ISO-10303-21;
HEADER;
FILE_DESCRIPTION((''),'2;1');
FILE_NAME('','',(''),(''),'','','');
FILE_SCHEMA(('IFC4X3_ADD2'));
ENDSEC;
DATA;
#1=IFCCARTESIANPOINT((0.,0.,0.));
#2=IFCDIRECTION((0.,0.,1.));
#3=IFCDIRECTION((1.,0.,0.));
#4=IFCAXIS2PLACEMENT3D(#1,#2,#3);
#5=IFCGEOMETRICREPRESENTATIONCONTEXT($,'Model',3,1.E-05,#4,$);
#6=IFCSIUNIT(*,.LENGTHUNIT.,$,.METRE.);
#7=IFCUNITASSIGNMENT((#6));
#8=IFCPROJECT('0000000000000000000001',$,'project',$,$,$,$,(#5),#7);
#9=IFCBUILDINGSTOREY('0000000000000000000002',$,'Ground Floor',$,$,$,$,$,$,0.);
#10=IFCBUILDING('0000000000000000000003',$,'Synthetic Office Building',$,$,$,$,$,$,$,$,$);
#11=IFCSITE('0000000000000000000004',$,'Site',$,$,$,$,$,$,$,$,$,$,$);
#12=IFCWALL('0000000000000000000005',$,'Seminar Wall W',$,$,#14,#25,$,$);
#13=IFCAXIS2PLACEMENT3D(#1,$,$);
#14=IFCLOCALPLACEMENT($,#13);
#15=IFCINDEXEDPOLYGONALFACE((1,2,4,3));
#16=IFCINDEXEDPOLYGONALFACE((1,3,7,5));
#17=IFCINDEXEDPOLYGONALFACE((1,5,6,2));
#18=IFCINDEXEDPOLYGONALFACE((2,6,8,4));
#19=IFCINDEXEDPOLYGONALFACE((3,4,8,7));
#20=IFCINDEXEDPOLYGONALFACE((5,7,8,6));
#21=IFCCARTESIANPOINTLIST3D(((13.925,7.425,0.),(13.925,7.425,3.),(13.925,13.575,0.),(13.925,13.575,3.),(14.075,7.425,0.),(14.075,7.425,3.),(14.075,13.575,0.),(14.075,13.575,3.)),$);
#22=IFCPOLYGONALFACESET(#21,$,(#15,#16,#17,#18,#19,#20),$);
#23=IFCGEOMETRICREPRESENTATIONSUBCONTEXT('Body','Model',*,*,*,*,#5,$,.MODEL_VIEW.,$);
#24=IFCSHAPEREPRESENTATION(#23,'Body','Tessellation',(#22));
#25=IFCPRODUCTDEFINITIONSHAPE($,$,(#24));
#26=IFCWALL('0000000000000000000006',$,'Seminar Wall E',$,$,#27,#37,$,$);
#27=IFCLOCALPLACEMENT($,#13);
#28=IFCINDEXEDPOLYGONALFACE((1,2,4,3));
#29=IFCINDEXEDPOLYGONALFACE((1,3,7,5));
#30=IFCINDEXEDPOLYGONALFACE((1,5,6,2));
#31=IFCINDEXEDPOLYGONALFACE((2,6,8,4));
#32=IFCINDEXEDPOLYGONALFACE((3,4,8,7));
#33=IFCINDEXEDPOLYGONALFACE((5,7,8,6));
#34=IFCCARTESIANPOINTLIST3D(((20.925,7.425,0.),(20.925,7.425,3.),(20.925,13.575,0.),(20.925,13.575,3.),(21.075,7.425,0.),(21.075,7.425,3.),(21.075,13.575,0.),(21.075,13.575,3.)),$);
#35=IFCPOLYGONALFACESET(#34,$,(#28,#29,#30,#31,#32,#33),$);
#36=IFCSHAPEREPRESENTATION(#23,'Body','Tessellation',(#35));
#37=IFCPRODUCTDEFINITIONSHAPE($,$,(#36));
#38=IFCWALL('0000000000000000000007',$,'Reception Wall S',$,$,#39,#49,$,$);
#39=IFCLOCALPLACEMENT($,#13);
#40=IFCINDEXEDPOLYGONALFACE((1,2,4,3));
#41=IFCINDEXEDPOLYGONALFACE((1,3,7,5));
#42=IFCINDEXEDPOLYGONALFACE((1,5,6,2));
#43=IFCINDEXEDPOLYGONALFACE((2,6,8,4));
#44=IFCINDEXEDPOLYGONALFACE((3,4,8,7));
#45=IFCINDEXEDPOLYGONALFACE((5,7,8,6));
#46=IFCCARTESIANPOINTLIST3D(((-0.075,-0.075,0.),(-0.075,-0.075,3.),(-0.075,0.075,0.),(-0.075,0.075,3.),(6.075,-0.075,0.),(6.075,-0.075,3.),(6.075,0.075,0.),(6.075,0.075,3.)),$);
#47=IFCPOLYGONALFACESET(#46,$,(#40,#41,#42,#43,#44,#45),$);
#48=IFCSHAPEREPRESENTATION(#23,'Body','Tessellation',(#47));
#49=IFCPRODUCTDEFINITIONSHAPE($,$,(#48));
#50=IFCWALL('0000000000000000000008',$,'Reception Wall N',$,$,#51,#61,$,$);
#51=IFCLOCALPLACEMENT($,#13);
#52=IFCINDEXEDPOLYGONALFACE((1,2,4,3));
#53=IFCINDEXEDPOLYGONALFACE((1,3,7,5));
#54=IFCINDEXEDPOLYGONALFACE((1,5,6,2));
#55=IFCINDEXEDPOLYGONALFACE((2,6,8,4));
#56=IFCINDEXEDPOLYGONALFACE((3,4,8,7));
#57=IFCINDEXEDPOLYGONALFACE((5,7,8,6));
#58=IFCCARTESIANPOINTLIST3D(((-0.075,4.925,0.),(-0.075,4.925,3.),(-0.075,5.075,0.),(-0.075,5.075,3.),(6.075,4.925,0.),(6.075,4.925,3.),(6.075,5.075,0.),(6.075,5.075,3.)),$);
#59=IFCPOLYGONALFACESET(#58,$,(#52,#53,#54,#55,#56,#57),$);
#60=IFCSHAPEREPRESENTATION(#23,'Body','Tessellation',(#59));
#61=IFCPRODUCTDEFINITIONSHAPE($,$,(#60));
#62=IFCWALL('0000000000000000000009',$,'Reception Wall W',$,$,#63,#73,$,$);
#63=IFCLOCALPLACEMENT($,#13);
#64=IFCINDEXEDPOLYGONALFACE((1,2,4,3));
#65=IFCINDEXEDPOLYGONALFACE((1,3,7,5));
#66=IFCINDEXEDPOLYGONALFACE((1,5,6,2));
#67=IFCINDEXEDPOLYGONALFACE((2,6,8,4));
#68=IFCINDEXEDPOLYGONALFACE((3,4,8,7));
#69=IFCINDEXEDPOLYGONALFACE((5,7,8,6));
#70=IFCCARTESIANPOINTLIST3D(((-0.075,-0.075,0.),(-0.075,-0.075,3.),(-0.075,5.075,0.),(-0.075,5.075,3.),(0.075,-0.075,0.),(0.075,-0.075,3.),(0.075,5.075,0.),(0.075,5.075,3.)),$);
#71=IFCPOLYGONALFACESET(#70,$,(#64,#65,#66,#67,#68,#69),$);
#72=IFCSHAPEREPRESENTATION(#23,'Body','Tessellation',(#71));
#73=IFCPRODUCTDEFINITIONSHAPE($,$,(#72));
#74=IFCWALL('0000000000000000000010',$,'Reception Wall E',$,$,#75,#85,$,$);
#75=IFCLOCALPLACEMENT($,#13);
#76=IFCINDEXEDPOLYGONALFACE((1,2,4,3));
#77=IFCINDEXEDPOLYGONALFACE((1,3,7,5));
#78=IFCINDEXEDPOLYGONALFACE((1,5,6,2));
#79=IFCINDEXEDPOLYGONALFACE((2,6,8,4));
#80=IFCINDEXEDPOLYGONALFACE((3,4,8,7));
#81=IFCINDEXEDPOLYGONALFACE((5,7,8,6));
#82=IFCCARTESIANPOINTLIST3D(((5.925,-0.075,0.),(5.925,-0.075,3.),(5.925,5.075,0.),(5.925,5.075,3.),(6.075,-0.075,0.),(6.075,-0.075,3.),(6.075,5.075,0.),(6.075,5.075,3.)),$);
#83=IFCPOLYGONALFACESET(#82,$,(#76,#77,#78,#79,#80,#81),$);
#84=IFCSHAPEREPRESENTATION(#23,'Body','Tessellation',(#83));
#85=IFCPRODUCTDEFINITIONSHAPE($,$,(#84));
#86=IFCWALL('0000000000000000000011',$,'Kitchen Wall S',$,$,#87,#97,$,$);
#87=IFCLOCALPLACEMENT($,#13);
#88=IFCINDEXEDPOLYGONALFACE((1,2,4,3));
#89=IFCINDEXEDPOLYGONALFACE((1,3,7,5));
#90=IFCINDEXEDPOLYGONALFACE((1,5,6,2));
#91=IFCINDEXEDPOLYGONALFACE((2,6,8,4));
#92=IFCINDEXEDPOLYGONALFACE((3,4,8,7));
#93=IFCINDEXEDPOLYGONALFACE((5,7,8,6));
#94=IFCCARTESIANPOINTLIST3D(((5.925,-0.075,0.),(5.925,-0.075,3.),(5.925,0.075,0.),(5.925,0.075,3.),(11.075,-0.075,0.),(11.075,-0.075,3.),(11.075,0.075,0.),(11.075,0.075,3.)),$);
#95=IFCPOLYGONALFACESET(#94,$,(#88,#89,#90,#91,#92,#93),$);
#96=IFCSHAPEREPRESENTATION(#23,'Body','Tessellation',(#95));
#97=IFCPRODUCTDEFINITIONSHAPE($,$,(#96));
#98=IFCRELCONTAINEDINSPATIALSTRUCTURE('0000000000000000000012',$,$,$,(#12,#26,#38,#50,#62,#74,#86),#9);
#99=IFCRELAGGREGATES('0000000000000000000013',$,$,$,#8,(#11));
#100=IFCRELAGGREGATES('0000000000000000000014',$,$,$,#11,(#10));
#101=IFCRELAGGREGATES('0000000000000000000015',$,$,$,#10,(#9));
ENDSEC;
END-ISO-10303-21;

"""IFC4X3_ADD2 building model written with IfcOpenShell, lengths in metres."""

from ifc_helpers import new_model, si_unit, origin_with_axes, place, context, subcontext, project, spatial, polyline, outline, extrude, element, save


model = new_model("IFC4X3_ADD2")

# Units and contexts
model_context = context("Model", 3, precision=1e-05, world=origin_with_axes())
body_context = subcontext(model_context, "Body", "Model", "MODEL_VIEW")
ifc_project = project(units=[si_unit("LENGTHUNIT", "METRE")], contexts=[model_context])

# Site, building, storey
site = spatial("IfcSite", under=ifc_project, Name="Site")
building = spatial("IfcBuilding", under=site, Name="Synthetic Office Building")
storey = spatial("IfcBuildingStorey", under=building, Name="Ground Floor", Elevation=0.0)

# Walls
wall_1_placement = place(None, origin_with_axes())
element("IfcWall", 1, at=wall_1_placement, inside=storey, Name="Seminar Wall W", context=body_context, shape_type="SweptSolid", body=[
    extrude(outline(polyline([(13.925, 7.425), (14.075, 7.425), (14.075, 13.575), (13.925, 13.575), (13.925, 7.425)])), origin_with_axes(), (0.0, 0.0, 1.0), 3.0),
])
wall_2_placement = place(None, origin_with_axes())
element("IfcWall", 2, at=wall_2_placement, inside=storey, Name="Seminar Wall E", context=body_context, shape_type="SweptSolid", body=[
    extrude(outline(polyline([(20.925, 7.425), (21.075, 7.425), (21.075, 13.575), (20.925, 13.575), (20.925, 7.425)])), origin_with_axes(), (0.0, 0.0, 1.0), 3.0),
])
wall_3_placement = place(None, origin_with_axes())
element("IfcWall", 3, at=wall_3_placement, inside=storey, Name="Reception Wall S", context=body_context, shape_type="SweptSolid", body=[
    extrude(outline(polyline([(-0.075, -0.075), (6.075, -0.075), (6.075, 0.075), (-0.075, 0.075), (-0.075, -0.075)])), origin_with_axes(), (0.0, 0.0, 1.0), 3.0),
])
wall_4_placement = place(None, origin_with_axes())
element("IfcWall", 4, at=wall_4_placement, inside=storey, Name="Reception Wall N", context=body_context, shape_type="SweptSolid", body=[
    extrude(outline(polyline([(-0.075, 4.925), (6.075, 4.925), (6.075, 5.075), (-0.075, 5.075), (-0.075, 4.925)])), origin_with_axes(), (0.0, 0.0, 1.0), 3.0),
])
wall_5_placement = place(None, origin_with_axes())
element("IfcWall", 5, at=wall_5_placement, inside=storey, Name="Reception Wall W", context=body_context, shape_type="SweptSolid", body=[
    extrude(outline(polyline([(-0.075, -0.075), (0.075, -0.075), (0.075, 5.075), (-0.075, 5.075), (-0.075, -0.075)])), origin_with_axes(), (0.0, 0.0, 1.0), 3.0),
])
wall_6_placement = place(None, origin_with_axes())
element("IfcWall", 6, at=wall_6_placement, inside=storey, Name="Reception Wall E", context=body_context, shape_type="SweptSolid", body=[
    extrude(outline(polyline([(5.925, -0.075), (6.075, -0.075), (6.075, 5.075), (5.925, 5.075), (5.925, -0.075)])), origin_with_axes(), (0.0, 0.0, 1.0), 3.0),
])
wall_7_placement = place(None, origin_with_axes())
element("IfcWall", 7, at=wall_7_placement, inside=storey, Name="Kitchen Wall S", context=body_context, shape_type="SweptSolid", body=[
    extrude(outline(polyline([(5.925, -0.075), (11.075, -0.075), (11.075, 0.075), (5.925, 0.075), (5.925, -0.075)])), origin_with_axes(), (0.0, 0.0, 1.0), 3.0),
])

save(model, "model.ifc")
